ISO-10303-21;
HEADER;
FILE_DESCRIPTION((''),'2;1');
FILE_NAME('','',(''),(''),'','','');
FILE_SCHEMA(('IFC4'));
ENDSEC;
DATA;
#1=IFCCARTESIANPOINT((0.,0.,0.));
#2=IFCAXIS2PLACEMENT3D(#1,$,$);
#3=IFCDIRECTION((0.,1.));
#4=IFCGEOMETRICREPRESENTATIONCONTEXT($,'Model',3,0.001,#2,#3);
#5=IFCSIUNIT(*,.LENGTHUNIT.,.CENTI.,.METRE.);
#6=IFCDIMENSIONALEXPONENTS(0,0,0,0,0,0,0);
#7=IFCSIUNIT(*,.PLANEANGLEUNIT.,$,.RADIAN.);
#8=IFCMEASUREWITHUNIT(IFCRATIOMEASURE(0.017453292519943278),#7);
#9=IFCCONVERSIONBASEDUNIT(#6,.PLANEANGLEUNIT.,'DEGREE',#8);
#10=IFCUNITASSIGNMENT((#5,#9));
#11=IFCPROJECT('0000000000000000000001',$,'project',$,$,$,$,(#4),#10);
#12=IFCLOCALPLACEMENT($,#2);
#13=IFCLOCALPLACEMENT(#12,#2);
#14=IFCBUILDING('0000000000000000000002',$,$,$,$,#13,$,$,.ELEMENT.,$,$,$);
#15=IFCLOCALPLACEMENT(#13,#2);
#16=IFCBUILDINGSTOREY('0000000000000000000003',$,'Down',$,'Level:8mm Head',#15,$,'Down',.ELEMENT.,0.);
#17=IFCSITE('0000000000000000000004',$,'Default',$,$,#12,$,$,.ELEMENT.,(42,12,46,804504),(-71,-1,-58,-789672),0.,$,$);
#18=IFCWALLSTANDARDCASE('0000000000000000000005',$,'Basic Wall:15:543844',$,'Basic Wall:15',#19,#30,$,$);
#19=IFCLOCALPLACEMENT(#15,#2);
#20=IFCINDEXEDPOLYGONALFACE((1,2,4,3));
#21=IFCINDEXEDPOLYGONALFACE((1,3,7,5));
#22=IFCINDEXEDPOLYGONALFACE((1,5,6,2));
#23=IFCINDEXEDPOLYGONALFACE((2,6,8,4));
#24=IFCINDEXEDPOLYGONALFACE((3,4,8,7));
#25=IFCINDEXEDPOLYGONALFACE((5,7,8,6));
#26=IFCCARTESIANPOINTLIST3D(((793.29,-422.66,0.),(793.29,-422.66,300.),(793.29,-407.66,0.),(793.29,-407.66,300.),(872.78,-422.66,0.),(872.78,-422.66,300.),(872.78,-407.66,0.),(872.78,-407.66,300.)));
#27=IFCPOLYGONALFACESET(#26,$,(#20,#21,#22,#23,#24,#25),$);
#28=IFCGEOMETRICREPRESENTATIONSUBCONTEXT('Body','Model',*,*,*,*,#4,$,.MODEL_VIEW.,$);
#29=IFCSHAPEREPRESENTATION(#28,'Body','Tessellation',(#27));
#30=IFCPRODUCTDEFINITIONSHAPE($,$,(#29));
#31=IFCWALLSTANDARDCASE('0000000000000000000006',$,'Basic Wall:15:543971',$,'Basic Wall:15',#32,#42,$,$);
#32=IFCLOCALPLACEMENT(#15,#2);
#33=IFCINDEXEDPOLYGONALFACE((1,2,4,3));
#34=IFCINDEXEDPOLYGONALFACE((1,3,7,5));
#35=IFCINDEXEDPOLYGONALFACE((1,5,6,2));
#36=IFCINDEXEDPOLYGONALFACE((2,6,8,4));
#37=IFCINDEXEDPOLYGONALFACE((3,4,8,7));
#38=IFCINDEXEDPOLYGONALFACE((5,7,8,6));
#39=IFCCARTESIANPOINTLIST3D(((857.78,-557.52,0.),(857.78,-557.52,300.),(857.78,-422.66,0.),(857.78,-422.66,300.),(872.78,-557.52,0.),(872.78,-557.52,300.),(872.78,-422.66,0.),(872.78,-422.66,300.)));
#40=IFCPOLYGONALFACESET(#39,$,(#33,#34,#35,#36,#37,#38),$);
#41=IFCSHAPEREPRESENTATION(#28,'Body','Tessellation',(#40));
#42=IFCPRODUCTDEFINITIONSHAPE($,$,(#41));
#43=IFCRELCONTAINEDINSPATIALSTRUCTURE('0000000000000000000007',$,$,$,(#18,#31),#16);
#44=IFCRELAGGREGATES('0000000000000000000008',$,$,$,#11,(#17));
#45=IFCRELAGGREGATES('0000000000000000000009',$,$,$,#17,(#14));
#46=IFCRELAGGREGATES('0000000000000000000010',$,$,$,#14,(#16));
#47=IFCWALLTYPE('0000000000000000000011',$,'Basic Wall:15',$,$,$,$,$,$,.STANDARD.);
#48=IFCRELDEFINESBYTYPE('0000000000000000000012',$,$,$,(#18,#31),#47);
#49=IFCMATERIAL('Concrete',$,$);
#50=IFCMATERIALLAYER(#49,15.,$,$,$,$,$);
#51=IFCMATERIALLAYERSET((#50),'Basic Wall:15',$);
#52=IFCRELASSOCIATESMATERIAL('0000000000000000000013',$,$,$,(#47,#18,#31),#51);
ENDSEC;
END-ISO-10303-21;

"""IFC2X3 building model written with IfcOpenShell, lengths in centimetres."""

from ifc_helpers import new_model, entity, si_unit, converted_unit, direction, frame, frame_2d, origin, place, context, subcontext, project, spatial, rectangle, extrude, material, layer, layer_set, layer_usage, type_object, element, save


model = new_model("IFC2X3")

# Units and contexts
model_context = context("Model", 3, precision=0.001, world=origin(), true_north=direction((0.0, 1.0)))
body_context = subcontext(model_context, "Body", "Model", "MODEL_VIEW")
ifc_project = project(units=[si_unit("LENGTHUNIT", "METRE", prefix="CENTI"), converted_unit("PLANEANGLEUNIT", "DEGREE", entity("IfcRatioMeasure", 0.017453292519943278), si_unit("PLANEANGLEUNIT", "RADIAN"), dimensions=[0, 0, 0, 0, 0, 0, 0])], contexts=[model_context])

# Site, building, storey
site_placement = place(None, origin())
site = spatial("IfcSite", under=ifc_project, at=site_placement, Name="Default", CompositionType="ELEMENT", RefLatitude=(42, 12, 46, 804504), RefLongitude=(-71, -1, -58, -789672), RefElevation=0.0)
building_placement = place(site_placement, origin())
building = spatial("IfcBuilding", under=site, at=building_placement, CompositionType="ELEMENT")
storey_placement = place(building_placement, origin())
storey = spatial("IfcBuildingStorey", under=building, at=storey_placement, Name="Down", ObjectType="Level:8mm Head", LongName="Down", CompositionType="ELEMENT", Elevation=0.0)

# Walls
ifc_material = material(Name="Concrete")
ifc_layer_1 = layer(ifc_material, 15.0)
ifc_layer_set_1 = layer_set([ifc_layer_1], Name="Basic Wall:15")
wall_type_1 = type_object("IfcWallType", Name="Basic Wall:15", PredefinedType="STANDARD", material=ifc_layer_set_1)
ifc_layer_usage_1 = layer_usage(ifc_layer_set_1, "AXIS2", "NEGATIVE", 7.5)
wall_1_placement = place(storey_placement, frame((793.29, -415.16, 0.0)))
element("IfcWallStandardCase", 1, at=wall_1_placement, inside=storey, type_object=wall_type_1, material=ifc_layer_usage_1, Name="Basic Wall:15:543844", ObjectType="Basic Wall:15", context=body_context, shape_type="SweptSolid", body=[
    extrude(rectangle(XDim=79.49, YDim=15.0, at=frame_2d((39.74, 0.0), x_axis=(-1.0, 0.0))), origin(), (0.0, 0.0, 1.0), 300.0),
])
ifc_layer_usage_2 = layer_usage(ifc_layer_set_1, "AXIS2", "NEGATIVE", 7.5)
wall_2_placement = place(storey_placement, frame((865.28, -422.66, 0.0), z_axis=(0.0, 0.0, 1.0), x_axis=(0.0, -1.0, 0.0)))
element("IfcWallStandardCase", 2, at=wall_2_placement, inside=storey, type_object=wall_type_1, material=ifc_layer_usage_2, Name="Basic Wall:15:543971", ObjectType="Basic Wall:15", context=body_context, shape_type="SweptSolid", body=[
    extrude(rectangle(XDim=134.86, YDim=15.0, at=frame_2d((67.43, 0.0), x_axis=(-1.0, 0.0))), origin(), (0.0, 0.0, 1.0), 300.0),
])

save(model, "model.ifc")
